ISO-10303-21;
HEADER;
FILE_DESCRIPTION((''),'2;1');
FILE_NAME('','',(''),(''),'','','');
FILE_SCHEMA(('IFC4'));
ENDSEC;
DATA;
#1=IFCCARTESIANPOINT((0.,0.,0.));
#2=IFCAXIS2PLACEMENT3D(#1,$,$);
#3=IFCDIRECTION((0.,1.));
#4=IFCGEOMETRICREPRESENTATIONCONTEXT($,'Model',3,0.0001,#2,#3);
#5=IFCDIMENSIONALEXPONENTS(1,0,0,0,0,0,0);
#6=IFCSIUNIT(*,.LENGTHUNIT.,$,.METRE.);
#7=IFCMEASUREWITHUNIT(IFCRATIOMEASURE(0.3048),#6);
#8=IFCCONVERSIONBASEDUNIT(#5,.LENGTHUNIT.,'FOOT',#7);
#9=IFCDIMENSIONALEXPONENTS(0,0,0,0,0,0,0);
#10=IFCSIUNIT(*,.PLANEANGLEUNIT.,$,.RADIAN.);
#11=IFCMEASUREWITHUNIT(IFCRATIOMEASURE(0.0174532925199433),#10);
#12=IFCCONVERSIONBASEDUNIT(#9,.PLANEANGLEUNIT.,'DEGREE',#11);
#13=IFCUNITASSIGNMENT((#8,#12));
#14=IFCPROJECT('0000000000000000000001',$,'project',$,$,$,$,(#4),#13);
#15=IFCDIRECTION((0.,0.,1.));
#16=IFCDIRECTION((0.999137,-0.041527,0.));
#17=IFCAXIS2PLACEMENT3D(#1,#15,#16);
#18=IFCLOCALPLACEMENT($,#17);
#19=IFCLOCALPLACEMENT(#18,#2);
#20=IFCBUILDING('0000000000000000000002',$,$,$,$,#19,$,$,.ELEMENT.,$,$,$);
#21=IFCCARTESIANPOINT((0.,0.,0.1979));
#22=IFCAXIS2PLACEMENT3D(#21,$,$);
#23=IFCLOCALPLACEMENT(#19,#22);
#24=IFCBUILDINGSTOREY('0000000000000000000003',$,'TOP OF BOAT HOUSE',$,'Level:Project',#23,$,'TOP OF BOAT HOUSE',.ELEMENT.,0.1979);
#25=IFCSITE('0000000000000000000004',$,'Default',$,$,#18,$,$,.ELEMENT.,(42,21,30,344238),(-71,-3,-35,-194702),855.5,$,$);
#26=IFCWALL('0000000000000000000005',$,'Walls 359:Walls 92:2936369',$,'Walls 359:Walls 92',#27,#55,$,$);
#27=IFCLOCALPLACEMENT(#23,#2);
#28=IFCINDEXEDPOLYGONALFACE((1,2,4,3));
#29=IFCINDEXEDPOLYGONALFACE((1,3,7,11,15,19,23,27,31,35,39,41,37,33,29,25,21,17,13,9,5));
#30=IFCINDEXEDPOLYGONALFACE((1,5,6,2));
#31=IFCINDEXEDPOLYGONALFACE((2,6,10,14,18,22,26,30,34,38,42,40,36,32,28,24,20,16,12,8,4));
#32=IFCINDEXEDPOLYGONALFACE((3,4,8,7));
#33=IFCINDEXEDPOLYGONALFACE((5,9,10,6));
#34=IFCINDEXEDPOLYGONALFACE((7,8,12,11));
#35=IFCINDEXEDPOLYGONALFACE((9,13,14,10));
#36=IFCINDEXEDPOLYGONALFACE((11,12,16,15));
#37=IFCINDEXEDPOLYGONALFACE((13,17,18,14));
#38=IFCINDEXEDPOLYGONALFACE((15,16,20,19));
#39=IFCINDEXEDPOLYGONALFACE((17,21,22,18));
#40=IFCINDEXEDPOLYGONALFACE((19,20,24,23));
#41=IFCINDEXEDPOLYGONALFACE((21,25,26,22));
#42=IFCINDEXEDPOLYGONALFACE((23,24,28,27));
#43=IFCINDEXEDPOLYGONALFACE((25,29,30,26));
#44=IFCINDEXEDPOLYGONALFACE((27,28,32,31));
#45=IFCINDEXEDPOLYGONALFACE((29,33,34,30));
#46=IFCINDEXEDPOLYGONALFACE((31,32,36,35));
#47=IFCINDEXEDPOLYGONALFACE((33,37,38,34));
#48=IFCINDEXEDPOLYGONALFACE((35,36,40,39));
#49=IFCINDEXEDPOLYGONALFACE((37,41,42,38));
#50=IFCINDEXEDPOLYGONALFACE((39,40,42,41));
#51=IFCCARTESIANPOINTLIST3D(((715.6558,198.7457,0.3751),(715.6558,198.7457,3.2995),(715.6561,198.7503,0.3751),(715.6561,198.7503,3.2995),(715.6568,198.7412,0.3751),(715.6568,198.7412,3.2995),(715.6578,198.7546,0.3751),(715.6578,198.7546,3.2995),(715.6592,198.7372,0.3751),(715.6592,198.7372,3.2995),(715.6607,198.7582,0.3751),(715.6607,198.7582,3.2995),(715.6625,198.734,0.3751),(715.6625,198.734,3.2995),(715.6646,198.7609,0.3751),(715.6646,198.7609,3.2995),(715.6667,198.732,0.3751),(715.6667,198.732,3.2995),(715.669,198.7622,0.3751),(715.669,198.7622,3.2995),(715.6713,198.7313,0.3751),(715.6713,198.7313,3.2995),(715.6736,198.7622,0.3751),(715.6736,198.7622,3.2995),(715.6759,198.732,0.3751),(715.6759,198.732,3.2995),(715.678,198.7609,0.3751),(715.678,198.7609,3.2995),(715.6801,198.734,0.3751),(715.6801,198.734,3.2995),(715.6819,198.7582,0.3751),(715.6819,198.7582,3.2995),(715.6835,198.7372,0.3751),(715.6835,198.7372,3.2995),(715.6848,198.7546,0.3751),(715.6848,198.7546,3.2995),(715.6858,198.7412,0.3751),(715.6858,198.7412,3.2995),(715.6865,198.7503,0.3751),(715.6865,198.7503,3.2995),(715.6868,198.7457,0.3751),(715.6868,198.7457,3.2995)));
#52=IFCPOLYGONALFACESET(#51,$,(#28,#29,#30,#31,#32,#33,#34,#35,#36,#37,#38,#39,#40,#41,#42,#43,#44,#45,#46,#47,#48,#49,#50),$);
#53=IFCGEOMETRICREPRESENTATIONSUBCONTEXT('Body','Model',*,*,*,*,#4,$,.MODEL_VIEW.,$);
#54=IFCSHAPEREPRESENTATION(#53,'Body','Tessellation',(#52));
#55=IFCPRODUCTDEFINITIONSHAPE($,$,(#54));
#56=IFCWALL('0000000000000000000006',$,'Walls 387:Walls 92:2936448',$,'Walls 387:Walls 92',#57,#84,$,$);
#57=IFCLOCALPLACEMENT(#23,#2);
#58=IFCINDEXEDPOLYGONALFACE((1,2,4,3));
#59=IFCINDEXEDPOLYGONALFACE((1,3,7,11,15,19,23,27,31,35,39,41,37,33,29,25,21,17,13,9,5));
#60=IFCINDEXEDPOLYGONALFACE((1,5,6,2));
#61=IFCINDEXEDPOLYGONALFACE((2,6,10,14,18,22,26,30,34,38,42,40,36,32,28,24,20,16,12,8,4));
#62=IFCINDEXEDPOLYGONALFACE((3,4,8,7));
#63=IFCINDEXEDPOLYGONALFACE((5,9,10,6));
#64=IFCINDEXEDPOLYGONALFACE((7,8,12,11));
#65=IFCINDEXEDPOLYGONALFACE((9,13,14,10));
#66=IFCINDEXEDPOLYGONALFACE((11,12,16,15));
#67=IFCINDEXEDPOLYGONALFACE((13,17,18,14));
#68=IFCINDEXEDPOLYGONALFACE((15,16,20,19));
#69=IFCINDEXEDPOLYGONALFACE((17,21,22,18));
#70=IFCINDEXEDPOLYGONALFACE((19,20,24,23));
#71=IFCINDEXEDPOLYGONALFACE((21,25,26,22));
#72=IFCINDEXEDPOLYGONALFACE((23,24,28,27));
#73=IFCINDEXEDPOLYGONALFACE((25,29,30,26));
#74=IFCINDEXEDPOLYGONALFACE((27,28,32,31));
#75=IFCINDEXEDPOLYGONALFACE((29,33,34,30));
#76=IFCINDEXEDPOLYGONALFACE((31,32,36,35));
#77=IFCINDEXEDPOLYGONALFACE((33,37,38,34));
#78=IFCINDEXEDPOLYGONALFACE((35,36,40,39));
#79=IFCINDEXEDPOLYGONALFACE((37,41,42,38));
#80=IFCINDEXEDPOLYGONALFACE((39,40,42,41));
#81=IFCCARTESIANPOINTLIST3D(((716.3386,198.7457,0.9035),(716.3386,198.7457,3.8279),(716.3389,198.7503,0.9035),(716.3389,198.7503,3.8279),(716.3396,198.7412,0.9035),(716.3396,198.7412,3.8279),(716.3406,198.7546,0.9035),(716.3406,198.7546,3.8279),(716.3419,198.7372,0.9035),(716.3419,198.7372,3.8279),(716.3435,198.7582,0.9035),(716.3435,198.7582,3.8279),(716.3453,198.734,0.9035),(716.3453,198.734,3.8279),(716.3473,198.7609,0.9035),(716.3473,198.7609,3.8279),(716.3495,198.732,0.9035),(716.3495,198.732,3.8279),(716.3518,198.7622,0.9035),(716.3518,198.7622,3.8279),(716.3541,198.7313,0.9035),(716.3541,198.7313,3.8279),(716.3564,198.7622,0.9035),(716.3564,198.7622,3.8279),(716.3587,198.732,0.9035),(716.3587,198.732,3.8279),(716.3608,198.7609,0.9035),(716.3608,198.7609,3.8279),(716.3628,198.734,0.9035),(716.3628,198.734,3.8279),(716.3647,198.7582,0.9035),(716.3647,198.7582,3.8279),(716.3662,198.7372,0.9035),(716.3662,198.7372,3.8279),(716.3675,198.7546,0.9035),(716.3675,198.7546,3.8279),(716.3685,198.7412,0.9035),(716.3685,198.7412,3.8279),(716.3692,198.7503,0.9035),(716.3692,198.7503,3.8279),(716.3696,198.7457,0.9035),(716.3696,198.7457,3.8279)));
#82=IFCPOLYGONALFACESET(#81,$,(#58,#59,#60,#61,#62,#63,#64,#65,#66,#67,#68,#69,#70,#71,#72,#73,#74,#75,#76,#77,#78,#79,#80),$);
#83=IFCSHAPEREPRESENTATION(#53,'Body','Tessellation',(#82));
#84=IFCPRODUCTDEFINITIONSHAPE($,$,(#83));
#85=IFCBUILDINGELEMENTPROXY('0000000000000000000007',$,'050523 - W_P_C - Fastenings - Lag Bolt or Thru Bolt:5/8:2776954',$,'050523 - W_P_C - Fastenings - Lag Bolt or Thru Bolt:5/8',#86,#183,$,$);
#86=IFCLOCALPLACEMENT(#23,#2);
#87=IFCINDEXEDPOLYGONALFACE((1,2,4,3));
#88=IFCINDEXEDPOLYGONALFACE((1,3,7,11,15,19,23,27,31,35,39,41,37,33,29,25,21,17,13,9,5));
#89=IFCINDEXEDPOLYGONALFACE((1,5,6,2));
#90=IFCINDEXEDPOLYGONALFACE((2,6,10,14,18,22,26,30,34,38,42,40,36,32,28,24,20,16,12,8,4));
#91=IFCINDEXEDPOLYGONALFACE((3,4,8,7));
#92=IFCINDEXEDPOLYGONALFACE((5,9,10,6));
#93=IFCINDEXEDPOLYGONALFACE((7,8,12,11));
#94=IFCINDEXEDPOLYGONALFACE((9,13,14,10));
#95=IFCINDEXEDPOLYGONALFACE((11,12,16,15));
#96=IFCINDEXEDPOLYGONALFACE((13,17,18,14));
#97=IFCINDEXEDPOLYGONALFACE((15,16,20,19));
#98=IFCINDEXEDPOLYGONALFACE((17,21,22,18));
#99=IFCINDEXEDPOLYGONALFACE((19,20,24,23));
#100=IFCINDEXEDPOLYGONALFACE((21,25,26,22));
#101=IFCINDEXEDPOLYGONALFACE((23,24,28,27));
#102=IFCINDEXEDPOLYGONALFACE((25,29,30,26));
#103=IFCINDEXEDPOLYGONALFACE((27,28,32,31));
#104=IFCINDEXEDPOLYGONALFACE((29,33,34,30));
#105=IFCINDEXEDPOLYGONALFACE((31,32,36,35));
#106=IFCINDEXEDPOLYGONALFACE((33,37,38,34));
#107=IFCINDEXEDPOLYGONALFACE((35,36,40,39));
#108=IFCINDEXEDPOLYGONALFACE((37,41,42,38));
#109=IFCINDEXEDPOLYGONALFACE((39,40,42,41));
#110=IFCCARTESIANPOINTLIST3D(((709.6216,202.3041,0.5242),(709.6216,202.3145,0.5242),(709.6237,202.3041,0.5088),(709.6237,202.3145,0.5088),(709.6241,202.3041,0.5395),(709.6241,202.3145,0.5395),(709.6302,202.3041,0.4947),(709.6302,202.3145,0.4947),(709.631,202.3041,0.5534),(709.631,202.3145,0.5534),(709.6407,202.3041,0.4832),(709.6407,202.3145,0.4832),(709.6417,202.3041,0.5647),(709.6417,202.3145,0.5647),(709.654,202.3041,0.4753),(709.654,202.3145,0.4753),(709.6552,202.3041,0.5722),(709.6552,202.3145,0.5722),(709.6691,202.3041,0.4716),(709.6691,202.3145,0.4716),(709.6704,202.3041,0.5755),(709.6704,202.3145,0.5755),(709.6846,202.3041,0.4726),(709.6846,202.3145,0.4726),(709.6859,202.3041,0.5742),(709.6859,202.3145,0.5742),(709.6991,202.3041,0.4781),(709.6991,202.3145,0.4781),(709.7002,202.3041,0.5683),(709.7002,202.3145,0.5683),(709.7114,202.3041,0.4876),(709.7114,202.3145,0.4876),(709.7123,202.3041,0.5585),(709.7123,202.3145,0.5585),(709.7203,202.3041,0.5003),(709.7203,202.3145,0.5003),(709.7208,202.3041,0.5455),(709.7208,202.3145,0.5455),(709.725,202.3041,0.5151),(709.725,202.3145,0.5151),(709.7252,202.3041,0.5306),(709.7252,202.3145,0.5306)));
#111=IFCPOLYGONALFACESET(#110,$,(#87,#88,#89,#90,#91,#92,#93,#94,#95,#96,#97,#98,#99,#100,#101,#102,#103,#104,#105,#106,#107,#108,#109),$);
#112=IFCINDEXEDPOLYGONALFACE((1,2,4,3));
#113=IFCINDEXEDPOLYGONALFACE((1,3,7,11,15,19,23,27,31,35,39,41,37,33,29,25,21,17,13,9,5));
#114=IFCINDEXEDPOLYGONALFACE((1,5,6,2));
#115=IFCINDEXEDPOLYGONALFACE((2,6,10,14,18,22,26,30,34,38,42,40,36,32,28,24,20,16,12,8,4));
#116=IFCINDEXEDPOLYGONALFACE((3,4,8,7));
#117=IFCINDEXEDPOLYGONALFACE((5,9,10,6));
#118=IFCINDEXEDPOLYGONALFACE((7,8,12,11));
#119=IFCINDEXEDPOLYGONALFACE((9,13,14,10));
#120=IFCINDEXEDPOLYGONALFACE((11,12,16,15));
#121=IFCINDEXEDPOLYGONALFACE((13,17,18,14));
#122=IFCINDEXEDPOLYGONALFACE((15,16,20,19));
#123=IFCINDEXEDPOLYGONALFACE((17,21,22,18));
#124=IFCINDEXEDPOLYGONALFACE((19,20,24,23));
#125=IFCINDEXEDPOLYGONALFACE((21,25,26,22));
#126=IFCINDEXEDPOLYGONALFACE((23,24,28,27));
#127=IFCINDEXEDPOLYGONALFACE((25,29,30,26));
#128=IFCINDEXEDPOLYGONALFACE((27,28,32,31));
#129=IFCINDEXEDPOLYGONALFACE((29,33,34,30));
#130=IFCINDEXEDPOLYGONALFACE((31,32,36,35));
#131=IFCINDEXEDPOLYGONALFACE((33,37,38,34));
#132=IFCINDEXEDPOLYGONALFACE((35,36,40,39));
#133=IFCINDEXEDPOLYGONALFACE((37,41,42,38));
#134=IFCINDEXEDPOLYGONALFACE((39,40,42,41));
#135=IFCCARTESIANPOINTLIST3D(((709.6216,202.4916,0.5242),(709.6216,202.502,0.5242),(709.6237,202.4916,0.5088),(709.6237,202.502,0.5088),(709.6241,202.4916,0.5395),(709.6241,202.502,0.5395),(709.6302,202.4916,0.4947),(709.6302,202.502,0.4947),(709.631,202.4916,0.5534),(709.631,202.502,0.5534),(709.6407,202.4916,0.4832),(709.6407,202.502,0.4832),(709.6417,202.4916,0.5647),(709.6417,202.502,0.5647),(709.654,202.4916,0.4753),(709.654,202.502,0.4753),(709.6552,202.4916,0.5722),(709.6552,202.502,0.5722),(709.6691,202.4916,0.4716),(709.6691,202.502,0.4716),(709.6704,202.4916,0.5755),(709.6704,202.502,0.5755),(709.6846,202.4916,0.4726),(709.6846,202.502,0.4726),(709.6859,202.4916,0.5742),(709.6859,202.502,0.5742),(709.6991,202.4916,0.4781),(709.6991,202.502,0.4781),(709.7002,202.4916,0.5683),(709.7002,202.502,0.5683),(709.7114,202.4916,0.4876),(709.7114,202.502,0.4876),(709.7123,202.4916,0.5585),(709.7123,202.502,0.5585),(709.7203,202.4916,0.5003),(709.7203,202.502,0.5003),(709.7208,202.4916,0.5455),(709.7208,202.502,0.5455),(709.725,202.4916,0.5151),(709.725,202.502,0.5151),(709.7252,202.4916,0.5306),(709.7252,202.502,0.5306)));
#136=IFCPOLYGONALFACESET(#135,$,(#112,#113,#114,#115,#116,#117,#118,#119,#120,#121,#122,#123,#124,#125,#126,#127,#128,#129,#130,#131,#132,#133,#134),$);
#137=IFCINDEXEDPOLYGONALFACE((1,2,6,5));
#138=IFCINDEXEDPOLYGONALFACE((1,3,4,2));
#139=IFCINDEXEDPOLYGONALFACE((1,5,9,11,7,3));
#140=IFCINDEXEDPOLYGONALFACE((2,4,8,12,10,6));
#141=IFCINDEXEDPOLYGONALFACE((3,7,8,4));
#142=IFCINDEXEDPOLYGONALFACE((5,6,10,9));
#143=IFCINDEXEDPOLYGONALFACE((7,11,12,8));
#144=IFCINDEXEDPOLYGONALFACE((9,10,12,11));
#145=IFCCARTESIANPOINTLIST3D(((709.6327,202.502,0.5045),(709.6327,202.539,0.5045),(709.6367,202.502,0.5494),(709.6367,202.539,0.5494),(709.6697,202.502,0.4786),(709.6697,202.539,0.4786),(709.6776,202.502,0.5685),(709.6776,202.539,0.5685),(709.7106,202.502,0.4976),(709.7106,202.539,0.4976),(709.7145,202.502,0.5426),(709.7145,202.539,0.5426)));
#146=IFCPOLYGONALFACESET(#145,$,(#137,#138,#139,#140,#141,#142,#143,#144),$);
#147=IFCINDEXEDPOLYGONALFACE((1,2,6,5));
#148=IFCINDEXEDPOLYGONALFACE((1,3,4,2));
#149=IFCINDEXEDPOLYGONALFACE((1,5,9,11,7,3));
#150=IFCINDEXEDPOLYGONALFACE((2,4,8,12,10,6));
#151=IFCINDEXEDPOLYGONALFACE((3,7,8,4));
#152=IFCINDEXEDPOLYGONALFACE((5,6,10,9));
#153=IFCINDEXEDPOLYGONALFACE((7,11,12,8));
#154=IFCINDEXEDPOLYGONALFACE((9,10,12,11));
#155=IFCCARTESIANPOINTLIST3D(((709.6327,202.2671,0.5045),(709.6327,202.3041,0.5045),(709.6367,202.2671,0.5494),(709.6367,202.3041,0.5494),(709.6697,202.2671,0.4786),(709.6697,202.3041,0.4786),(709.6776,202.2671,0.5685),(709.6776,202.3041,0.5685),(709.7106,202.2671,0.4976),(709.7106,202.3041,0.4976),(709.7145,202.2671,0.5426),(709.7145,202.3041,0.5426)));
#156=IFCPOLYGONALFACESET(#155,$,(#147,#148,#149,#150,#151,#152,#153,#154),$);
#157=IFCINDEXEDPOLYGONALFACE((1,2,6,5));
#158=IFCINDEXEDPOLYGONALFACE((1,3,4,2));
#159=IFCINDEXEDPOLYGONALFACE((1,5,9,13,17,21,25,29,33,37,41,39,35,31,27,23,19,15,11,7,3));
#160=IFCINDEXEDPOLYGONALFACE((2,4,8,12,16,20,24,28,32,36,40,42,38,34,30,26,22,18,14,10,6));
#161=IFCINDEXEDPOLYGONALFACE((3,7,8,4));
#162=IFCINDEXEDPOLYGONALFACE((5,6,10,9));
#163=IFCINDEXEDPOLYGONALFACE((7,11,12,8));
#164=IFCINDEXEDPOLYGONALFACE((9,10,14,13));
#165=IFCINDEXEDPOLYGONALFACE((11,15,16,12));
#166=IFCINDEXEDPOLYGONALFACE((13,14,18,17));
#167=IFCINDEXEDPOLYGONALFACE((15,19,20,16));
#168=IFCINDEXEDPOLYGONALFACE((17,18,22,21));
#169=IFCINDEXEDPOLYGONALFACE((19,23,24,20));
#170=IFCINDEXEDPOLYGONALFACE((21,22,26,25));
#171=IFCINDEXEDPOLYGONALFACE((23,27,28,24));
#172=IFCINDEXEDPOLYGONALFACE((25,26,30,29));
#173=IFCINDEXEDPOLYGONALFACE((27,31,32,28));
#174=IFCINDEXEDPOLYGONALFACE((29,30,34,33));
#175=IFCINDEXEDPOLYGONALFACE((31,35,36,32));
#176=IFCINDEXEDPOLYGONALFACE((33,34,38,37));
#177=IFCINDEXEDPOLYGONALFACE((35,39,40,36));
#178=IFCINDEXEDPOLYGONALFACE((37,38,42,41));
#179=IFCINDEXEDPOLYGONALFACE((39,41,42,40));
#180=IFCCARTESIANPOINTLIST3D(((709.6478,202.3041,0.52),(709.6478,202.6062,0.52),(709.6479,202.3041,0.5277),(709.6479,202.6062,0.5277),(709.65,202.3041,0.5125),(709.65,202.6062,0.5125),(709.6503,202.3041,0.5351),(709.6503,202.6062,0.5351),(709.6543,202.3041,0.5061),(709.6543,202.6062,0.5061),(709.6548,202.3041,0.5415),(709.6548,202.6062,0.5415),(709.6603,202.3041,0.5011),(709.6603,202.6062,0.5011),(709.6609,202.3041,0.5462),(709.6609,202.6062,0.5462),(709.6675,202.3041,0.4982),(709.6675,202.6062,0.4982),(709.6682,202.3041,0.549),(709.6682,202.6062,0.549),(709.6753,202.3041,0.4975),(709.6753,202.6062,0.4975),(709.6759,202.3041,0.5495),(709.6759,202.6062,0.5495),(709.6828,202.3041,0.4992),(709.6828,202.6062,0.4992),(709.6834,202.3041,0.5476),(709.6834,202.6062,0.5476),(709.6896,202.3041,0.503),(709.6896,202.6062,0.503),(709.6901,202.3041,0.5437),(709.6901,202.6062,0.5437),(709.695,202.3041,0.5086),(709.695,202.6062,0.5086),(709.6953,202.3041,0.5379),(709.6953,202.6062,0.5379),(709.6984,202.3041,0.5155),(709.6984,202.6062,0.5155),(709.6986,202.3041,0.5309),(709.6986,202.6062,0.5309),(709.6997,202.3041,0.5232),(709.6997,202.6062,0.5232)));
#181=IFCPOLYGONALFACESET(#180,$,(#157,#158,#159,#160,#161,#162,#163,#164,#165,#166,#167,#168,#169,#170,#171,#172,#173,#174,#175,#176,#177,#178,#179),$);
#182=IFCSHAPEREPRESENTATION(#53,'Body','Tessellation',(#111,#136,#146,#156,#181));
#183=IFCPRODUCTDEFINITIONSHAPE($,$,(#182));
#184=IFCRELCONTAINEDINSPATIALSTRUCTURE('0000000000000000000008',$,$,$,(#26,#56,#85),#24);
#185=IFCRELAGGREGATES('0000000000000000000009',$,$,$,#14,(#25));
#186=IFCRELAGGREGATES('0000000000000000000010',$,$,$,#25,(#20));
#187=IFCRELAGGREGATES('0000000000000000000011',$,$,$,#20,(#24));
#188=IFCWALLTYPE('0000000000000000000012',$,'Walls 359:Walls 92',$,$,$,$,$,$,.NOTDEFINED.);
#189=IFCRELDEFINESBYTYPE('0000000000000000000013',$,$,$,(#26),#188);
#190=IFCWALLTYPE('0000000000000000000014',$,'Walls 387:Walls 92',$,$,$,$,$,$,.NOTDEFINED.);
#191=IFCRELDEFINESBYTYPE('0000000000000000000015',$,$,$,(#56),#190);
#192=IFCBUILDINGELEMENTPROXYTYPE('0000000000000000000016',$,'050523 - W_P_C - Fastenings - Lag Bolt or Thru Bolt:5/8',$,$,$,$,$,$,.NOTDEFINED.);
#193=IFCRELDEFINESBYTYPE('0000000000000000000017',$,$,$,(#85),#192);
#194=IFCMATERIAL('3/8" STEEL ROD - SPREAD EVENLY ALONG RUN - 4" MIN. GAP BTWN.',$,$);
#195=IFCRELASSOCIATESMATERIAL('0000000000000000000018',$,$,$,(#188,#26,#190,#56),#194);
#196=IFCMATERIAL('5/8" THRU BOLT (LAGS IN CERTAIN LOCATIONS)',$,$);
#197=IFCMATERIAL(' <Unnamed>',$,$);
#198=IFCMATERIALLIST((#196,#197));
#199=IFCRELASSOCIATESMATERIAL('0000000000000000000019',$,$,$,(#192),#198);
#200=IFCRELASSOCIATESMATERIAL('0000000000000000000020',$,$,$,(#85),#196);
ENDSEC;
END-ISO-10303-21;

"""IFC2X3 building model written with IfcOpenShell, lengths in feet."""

from ifc_helpers import new_model, entity, si_unit, converted_unit, direction, frame, frame_2d, origin, origin_2d_with_axis, place, context, subcontext, project, spatial, polyline, circle, outline, extrude, source, transform, mapped, material, material_list, type_object, type_shapes, element, save


model = new_model("IFC2X3")

# Units and contexts
model_context = context("Model", 3, precision=0.0001, world=origin(), true_north=direction((0.0, 1.0)))
body_context = subcontext(model_context, "Body", "Model", "MODEL_VIEW")
ifc_project = project(units=[converted_unit("LENGTHUNIT", "FOOT", entity("IfcRatioMeasure", 0.3048), si_unit("LENGTHUNIT", "METRE"), dimensions=[1, 0, 0, 0, 0, 0, 0]), converted_unit("PLANEANGLEUNIT", "DEGREE", entity("IfcRatioMeasure", 0.0174532925199433), si_unit("PLANEANGLEUNIT", "RADIAN"), dimensions=[0, 0, 0, 0, 0, 0, 0])], contexts=[model_context])

# Site, building, storey
site_placement = place(None, frame((0.0, 0.0, 0.0), z_axis=(0.0, 0.0, 1.0), x_axis=(0.999137, -0.041527, 0.0)))
site = spatial("IfcSite", under=ifc_project, at=site_placement, Name="Default", CompositionType="ELEMENT", RefLatitude=(42, 21, 30, 344238), RefLongitude=(-71, -3, -35, -194702), RefElevation=855.5)
building_placement = place(site_placement, origin())
building = spatial("IfcBuilding", under=site, at=building_placement, CompositionType="ELEMENT")
storey_placement = place(building_placement, frame((0.0, 0.0, 0.1979)))
storey = spatial("IfcBuildingStorey", under=building, at=storey_placement, Name="TOP OF BOAT HOUSE", ObjectType="Level:Project", LongName="TOP OF BOAT HOUSE", CompositionType="ELEMENT", Elevation=0.1979)

# Walls
ifc_material_1 = material(Name="3/8\" STEEL ROD - SPREAD EVENLY ALONG RUN - 4\" MIN. GAP BTWN.")
wall_type_1 = type_object("IfcWallType", Name="Walls 359:Walls 92", PredefinedType="NOTDEFINED", material=ifc_material_1)
wall_1_placement = place(storey_placement, frame((715.6558, 198.7313, 0.3751)))
element("IfcWall", 1, at=wall_1_placement, inside=storey, type_object=wall_type_1, material=ifc_material_1, Name="Walls 359:Walls 92:2936369", ObjectType="Walls 359:Walls 92", context=body_context, shape_type="SweptSolid", body=[
    extrude(circle(Radius=0.0155, at=origin_2d_with_axis()), frame((0.0155, 0.0155, 0.0), z_axis=(0.0, 0.0, 1.0), x_axis=(0.0, -1.0, 0.0)), (0.0, 0.0, 1.0), 2.9244),
])
wall_type_2 = type_object("IfcWallType", Name="Walls 387:Walls 92", PredefinedType="NOTDEFINED", material=ifc_material_1)
wall_2_placement = place(storey_placement, frame((716.3385, 198.7313, 0.9035)))
element("IfcWall", 2, at=wall_2_placement, inside=storey, type_object=wall_type_2, material=ifc_material_1, Name="Walls 387:Walls 92:2936448", ObjectType="Walls 387:Walls 92", context=body_context, shape_type="SweptSolid", body=[
    extrude(circle(Radius=0.0155, at=origin_2d_with_axis()), frame((0.0155, 0.0155, 0.0), z_axis=(0.0, 0.0, 1.0), x_axis=(0.0, -1.0, 0.0)), (0.0, 0.0, 1.0), 2.9244),
])

# Building element proxy
ifc_material_2 = material(Name="5/8\" THRU BOLT (LAGS IN CERTAIN LOCATIONS)")
ifc_material_3 = material(Name=" <Unnamed>")
ifc_material_list_1 = material_list([ifc_material_2, ifc_material_3])
building_element_proxy_type_1 = type_object("IfcBuildingElementProxyType", Name="050523 - W_P_C - Fastenings - Lag Bolt or Thru Bolt:5/8", PredefinedType="NOTDEFINED", material=ifc_material_list_1)
shared_shape_1 = source(origin(), body_context, "Body", "SweptSolid", [
    extrude(circle(Radius=0.0521, at=frame_2d((0.0, 0.0), x_axis=(1.0, 0.0))), frame((0.0, 0.0, 0.0), z_axis=(0.0, 0.0, 1.0), x_axis=(0.0, -1.0, 0.0)), (0.0, 0.0, 1.0), 0.0104),
    extrude(circle(Radius=0.0521, at=frame_2d((0.0, 0.0), x_axis=(1.0, 0.0))), frame((0.0, 0.0, -0.1875), z_axis=(0.0, 0.0, 1.0), x_axis=(0.0, -1.0, 0.0)), (0.0, 0.0, 1.0), 0.0104),
    extrude(outline(polyline([(-0.0226, -0.0391), (0.0226, -0.0391), (0.0451, 0.0), (0.0226, 0.0391), (-0.0226, 0.0391), (-0.0451, 0.0), (-0.0226, -0.0391)])), frame((0.0, 0.0, -0.2245), z_axis=(0.0, 0.0, 1.0), x_axis=(0.866025, -0.5, 0.0)), (0.0, 0.0, 1.0), 0.037),
    extrude(outline(polyline([(-0.0226, -0.0391), (0.0226, -0.0391), (0.0451, 0.0), (0.0226, 0.0391), (-0.0226, 0.0391), (-0.0451, 0.0), (-0.0226, -0.0391)])), frame((0.0, 0.0, 0.0104), z_axis=(0.0, 0.0, 1.0), x_axis=(0.0, -1.0, 0.0)), (0.0, 0.0, 1.0), 0.037),
    extrude(circle(Radius=0.026, at=frame_2d((0.0, 0.0), x_axis=(1.0, 0.0))), frame((0.0, 0.0, -0.2917), z_axis=(0.0, 0.0, 1.0), x_axis=(0.0, 1.0, 0.0)), (0.0, 0.0, 1.0), 0.3021),
])
type_shapes(building_element_proxy_type_1, [shared_shape_1])
for number, where, z_axis, x_axis, name in (
    (3, (709.6736, 202.3145, 0.5235), (0.0, -1.0, 0.0), (0.996195, 0.0, -0.087156), "050523 - W_P_C - Fastenings - Lag Bolt or Thru Bolt:5/8:2776954"),
):
    element("IfcBuildingElementProxy", number, at=place(storey_placement, frame(where, z_axis=z_axis, x_axis=x_axis)), inside=storey, type_object=building_element_proxy_type_1, material=ifc_material_2, Name=name, ObjectType="050523 - W_P_C - Fastenings - Lag Bolt or Thru Bolt:5/8", context=body_context, shape_type="MappedRepresentation", body=[
        mapped(shared_shape_1, transform((0.0, 0.0, 0.0), scale=1.0)),
    ])

save(model, "model.ifc")
